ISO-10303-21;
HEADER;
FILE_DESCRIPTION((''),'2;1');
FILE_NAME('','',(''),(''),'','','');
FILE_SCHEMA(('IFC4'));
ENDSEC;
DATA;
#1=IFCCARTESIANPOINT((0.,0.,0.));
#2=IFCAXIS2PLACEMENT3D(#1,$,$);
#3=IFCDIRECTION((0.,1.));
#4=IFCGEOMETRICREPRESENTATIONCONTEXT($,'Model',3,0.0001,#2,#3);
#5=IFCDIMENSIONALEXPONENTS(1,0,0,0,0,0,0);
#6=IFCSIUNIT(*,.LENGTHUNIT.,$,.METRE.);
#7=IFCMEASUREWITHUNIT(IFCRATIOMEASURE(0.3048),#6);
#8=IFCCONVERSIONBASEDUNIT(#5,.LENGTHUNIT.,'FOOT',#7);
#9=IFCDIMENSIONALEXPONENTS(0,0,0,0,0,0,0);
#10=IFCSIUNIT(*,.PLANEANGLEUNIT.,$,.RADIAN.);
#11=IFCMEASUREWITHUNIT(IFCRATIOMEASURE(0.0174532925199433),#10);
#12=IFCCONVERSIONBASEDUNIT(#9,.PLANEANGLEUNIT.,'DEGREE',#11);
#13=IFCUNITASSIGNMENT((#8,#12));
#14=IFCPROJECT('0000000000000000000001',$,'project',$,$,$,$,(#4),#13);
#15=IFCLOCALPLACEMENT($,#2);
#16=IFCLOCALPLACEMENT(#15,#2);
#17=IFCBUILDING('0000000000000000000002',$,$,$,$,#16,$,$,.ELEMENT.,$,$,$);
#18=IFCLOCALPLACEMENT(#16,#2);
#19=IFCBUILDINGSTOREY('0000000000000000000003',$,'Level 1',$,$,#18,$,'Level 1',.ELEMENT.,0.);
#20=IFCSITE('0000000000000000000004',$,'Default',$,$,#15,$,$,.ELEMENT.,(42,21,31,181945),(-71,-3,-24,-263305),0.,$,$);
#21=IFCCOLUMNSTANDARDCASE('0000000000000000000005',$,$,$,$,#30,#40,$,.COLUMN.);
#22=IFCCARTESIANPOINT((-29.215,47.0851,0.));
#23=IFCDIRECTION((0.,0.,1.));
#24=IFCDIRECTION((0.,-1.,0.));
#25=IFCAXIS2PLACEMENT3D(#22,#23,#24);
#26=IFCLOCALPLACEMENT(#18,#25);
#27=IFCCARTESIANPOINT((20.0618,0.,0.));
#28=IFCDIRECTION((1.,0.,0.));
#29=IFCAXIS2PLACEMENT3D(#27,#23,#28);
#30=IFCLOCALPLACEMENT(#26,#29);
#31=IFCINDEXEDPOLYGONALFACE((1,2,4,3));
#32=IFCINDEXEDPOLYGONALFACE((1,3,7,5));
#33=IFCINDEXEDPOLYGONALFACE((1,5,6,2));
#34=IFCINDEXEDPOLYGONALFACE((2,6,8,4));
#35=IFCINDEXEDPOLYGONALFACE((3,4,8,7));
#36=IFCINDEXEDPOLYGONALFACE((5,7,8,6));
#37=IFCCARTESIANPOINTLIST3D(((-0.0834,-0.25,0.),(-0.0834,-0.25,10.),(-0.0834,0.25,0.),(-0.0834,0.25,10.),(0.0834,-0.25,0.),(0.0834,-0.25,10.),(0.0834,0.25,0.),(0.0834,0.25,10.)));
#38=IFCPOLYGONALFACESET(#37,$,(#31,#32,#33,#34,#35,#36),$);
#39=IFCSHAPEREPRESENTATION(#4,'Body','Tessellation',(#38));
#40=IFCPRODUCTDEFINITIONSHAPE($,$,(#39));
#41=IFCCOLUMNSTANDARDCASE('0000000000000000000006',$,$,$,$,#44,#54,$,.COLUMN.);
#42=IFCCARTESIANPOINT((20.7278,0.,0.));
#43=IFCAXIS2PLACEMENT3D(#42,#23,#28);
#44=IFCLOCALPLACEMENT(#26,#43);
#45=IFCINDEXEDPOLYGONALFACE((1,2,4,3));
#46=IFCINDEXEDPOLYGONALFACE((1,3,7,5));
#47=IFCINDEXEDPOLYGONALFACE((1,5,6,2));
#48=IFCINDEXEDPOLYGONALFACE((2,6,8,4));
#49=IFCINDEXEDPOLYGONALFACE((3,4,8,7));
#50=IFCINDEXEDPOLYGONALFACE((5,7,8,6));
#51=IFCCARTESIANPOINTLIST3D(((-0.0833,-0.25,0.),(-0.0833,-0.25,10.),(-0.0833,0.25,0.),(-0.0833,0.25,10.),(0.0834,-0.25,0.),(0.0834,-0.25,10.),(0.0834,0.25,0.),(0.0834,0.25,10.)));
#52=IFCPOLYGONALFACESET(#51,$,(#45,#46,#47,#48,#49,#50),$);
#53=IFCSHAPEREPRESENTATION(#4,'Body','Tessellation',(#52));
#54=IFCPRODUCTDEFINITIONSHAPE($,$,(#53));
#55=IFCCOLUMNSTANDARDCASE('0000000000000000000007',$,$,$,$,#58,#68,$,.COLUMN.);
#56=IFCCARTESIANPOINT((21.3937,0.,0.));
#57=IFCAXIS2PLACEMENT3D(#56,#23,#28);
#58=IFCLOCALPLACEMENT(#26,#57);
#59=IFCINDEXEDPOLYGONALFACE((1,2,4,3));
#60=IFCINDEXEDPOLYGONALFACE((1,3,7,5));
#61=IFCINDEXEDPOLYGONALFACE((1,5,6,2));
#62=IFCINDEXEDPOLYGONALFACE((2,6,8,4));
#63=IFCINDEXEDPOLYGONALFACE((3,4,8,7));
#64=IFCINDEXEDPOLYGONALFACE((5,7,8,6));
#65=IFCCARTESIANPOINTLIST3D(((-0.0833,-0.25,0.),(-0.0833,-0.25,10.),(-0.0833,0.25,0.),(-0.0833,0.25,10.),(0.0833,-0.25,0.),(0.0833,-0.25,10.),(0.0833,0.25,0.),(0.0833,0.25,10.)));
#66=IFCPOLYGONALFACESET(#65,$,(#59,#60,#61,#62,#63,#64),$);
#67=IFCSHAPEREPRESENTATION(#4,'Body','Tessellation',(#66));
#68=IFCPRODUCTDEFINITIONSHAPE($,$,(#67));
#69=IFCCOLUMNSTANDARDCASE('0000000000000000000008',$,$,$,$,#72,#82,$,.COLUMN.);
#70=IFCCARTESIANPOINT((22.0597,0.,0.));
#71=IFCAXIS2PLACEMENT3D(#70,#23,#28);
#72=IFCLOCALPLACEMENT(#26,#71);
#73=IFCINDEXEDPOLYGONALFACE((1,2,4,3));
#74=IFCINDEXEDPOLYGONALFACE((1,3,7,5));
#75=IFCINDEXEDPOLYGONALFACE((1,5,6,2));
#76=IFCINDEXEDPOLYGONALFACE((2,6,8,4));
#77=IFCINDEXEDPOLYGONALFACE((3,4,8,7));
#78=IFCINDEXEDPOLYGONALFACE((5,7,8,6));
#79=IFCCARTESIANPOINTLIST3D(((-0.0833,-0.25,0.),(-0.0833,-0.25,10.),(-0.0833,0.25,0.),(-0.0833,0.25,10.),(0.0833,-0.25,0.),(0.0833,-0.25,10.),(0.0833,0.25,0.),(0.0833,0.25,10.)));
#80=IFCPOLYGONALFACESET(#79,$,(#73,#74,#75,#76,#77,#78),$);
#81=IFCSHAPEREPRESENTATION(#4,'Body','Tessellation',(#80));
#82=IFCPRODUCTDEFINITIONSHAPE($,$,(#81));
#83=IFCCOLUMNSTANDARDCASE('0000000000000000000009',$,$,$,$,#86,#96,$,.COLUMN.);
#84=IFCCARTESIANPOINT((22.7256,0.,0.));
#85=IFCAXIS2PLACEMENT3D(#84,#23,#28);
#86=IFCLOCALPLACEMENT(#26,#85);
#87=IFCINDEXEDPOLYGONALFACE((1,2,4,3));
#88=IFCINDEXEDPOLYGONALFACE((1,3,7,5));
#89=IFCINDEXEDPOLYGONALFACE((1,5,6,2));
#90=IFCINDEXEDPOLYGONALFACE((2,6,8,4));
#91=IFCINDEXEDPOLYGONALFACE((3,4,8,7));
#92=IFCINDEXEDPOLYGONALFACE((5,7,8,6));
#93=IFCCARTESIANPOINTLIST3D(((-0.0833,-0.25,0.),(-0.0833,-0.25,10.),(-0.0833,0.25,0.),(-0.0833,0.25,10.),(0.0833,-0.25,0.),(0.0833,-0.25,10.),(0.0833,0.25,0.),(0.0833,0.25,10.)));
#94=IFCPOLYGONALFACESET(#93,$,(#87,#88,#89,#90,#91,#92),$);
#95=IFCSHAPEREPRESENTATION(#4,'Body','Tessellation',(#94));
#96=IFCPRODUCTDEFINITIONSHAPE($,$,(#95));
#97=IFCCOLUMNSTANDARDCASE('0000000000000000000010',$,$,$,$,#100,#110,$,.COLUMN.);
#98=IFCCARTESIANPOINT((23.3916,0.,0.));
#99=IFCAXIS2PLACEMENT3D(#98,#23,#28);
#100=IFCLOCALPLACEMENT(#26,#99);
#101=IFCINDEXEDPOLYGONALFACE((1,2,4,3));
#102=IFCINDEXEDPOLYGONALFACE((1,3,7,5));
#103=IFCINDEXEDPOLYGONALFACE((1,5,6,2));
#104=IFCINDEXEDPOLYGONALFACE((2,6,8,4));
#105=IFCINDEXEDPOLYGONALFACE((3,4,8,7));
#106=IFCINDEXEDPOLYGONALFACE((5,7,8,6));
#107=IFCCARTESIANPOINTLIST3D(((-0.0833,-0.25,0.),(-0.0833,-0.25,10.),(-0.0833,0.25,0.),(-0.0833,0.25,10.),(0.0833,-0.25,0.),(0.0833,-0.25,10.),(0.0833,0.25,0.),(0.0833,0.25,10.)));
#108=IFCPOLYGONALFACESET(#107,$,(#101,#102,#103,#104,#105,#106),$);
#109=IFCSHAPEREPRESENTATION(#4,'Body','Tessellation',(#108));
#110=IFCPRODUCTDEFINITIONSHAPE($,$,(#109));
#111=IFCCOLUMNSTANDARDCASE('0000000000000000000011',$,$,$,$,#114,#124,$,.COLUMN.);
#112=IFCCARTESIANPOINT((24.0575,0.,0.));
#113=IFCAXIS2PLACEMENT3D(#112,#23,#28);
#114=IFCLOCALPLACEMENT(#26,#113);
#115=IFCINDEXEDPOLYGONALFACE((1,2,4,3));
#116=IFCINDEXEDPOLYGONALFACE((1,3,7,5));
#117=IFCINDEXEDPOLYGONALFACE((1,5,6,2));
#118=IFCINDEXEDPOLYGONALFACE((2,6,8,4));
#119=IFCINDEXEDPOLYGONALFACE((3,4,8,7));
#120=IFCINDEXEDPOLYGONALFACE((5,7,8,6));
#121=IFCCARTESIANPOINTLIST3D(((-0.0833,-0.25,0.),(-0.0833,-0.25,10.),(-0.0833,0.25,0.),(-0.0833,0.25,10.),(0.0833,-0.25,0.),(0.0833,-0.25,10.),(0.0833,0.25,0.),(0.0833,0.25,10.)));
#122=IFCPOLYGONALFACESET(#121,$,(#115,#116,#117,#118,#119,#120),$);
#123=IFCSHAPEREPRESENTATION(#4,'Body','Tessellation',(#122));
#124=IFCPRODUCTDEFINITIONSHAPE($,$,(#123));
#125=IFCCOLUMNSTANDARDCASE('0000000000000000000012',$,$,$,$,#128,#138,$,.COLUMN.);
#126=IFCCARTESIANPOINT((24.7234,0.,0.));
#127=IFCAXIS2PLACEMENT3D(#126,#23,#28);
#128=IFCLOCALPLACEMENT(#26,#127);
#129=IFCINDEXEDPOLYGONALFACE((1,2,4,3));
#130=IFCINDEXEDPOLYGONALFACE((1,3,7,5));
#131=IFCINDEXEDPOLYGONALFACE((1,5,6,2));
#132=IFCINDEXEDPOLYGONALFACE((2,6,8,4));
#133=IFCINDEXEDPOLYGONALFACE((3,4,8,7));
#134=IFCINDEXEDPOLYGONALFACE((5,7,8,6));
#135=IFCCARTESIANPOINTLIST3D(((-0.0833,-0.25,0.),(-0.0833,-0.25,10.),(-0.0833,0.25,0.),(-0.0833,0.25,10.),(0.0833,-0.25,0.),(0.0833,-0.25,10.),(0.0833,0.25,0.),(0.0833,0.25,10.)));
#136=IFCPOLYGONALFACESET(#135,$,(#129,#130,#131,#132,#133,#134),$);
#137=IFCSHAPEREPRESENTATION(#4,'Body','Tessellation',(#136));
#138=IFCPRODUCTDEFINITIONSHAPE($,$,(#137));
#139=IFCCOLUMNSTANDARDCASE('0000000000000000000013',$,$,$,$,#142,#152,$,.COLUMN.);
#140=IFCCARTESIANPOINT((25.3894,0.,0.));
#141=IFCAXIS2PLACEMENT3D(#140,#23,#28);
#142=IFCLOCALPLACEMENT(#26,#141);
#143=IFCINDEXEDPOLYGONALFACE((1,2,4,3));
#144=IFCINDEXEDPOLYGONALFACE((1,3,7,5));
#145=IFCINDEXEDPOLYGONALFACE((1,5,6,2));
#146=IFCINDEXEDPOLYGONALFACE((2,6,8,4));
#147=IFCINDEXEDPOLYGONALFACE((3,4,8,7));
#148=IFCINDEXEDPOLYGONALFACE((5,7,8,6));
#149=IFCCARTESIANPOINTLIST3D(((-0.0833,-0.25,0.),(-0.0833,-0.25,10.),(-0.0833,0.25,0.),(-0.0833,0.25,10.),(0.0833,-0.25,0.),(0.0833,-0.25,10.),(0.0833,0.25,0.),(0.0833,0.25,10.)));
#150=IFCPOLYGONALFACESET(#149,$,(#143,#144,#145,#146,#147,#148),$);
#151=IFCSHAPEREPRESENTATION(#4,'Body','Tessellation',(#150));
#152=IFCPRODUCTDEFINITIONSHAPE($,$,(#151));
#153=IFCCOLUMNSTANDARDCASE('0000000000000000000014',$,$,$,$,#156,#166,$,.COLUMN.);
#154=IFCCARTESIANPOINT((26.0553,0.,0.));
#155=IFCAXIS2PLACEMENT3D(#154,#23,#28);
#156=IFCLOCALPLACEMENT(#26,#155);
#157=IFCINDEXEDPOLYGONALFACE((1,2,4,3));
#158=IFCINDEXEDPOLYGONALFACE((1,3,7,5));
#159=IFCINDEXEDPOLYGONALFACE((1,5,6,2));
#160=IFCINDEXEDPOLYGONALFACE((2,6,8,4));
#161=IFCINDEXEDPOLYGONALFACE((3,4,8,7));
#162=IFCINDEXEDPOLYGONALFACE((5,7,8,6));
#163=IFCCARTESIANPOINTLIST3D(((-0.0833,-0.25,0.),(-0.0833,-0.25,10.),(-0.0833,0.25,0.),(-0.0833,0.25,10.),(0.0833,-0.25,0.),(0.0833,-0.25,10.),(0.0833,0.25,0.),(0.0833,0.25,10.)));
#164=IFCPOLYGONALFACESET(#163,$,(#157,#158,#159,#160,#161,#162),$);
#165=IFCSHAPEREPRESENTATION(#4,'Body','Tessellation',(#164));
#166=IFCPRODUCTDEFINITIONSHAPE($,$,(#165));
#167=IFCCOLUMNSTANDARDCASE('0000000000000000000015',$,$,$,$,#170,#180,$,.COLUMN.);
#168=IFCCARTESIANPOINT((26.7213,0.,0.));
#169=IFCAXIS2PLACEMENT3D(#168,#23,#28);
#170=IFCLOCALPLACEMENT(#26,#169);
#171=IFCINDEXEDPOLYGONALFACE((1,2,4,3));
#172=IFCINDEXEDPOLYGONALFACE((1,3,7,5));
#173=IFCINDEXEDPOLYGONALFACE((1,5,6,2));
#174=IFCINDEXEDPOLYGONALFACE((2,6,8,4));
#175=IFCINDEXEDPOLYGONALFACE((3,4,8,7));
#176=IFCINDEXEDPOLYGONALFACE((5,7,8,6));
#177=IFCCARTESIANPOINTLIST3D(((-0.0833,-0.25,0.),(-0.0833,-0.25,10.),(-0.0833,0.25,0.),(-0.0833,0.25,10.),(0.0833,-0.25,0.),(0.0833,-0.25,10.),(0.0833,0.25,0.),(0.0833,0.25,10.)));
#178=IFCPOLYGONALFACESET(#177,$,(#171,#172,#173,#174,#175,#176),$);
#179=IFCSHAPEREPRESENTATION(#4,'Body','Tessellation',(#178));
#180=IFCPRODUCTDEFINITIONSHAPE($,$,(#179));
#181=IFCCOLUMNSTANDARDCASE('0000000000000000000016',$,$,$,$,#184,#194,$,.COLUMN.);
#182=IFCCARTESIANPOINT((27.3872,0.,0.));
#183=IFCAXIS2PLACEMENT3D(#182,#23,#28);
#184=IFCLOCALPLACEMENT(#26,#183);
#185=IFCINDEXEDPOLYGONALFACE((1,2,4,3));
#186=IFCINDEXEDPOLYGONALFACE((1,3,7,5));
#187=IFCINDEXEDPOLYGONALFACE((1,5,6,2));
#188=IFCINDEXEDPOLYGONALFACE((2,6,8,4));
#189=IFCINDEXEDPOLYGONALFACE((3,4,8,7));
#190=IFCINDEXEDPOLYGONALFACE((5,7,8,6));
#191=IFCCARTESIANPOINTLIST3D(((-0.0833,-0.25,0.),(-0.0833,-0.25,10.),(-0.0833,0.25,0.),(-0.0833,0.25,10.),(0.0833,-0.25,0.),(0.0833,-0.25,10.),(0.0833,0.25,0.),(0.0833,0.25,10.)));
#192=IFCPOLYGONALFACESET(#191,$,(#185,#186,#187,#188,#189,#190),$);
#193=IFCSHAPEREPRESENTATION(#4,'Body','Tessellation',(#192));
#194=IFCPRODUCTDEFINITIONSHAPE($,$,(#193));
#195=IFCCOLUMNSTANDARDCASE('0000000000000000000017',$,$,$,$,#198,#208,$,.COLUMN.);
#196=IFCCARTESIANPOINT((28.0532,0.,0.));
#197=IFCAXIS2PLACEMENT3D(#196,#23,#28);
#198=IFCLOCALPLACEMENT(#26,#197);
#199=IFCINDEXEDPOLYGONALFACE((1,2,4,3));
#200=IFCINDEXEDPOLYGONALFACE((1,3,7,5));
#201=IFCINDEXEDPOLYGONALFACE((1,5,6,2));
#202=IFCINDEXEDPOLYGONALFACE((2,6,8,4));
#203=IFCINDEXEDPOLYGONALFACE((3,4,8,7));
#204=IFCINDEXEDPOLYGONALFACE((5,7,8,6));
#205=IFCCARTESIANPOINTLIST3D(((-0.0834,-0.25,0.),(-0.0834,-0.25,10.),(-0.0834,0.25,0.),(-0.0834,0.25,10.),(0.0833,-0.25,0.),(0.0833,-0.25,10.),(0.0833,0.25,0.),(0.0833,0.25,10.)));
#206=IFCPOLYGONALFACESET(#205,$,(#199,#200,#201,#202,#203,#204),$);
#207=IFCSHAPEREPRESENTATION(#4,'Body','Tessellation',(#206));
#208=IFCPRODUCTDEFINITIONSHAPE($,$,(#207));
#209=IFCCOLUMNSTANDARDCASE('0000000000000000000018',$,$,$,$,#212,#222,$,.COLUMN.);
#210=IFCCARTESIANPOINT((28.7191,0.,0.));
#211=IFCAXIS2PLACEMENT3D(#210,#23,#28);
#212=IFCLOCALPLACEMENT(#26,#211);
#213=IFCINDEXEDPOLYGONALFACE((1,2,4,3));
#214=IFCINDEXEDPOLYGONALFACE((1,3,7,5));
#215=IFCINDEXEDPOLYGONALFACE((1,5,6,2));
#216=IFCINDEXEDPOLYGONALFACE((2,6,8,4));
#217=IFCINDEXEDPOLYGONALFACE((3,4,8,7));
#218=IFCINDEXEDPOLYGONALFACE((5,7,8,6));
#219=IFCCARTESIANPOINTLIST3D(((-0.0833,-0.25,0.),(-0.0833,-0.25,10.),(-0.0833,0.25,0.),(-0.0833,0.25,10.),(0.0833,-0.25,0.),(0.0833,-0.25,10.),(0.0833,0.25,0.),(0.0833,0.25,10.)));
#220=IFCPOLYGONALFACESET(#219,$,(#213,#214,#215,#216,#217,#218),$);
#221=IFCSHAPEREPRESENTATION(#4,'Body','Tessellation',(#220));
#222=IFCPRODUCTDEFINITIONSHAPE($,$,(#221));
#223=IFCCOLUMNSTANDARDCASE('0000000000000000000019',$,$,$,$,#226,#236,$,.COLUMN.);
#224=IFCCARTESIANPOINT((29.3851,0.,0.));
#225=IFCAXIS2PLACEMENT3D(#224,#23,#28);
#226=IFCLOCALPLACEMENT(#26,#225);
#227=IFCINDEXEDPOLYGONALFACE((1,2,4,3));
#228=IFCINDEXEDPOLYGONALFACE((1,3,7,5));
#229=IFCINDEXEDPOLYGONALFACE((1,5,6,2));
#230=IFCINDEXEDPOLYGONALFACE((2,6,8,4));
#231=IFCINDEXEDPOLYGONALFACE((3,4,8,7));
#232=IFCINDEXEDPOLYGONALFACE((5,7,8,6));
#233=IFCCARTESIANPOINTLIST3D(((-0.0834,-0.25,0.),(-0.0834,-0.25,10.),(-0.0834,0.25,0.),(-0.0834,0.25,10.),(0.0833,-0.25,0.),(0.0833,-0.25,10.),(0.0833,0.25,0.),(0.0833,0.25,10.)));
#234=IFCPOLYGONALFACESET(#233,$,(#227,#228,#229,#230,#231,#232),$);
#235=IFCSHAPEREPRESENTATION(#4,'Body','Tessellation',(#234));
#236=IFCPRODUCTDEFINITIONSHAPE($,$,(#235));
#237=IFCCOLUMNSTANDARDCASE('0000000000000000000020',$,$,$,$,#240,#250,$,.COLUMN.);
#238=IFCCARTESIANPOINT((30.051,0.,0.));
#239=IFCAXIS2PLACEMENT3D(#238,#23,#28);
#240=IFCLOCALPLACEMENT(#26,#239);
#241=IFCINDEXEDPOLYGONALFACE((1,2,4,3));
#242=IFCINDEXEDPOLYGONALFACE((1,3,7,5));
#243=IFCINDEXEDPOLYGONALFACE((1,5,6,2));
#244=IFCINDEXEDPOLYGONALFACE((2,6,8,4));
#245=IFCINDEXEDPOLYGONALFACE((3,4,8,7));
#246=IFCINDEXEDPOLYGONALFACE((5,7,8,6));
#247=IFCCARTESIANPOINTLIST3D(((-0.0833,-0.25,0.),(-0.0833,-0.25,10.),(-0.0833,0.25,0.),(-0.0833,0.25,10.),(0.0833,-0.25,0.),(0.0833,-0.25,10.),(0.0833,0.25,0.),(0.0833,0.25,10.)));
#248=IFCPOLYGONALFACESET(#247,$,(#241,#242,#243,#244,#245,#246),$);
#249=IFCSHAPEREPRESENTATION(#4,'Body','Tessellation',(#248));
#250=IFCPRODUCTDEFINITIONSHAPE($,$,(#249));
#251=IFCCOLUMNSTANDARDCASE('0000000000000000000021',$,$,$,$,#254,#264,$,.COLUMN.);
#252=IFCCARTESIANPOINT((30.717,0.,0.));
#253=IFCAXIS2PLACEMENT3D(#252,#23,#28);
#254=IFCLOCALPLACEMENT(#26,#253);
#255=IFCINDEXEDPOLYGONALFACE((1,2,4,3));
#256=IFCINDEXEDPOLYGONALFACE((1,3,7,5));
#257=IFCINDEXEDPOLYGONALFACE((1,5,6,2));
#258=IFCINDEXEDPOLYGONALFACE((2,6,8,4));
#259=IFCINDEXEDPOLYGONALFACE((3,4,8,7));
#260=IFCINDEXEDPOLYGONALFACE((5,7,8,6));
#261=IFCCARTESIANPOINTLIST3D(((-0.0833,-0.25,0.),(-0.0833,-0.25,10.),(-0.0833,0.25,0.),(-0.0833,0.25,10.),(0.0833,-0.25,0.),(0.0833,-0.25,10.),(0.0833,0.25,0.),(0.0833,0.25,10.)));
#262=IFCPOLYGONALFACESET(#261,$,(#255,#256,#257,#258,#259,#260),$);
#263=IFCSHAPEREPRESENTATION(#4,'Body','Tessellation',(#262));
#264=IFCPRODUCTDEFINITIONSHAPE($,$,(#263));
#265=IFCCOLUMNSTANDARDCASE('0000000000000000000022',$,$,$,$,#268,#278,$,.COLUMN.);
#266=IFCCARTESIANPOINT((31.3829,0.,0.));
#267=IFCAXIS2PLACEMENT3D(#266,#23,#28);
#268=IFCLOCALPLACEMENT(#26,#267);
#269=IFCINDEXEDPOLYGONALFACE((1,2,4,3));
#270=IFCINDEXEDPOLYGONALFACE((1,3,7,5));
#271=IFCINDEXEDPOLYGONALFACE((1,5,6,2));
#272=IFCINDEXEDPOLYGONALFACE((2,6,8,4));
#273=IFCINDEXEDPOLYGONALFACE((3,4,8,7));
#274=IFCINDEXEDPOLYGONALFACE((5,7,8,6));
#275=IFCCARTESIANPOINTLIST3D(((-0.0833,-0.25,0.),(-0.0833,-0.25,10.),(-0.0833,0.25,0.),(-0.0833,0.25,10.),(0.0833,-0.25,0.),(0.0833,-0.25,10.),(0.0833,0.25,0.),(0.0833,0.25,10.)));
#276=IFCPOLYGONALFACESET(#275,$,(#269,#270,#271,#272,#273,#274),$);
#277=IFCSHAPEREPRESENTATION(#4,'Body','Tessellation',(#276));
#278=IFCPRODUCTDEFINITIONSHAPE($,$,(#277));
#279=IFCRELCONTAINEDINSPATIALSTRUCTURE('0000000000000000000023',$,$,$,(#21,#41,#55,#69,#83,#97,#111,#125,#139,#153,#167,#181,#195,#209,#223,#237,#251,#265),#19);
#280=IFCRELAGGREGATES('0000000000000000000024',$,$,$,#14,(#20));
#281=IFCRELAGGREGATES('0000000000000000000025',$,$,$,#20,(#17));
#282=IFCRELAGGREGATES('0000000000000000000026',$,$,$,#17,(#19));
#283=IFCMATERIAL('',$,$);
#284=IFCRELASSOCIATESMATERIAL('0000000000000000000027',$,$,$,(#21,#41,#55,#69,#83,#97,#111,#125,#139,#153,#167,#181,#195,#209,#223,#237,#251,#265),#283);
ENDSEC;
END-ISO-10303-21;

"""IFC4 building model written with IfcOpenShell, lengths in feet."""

from ifc_helpers import new_model, entity, si_unit, converted_unit, direction, frame, origin, place, context, project, spatial, rectangle, extrude, material, element, save


model = new_model("IFC4")

# Units and contexts
model_context = context("Model", 3, precision=0.0001, world=origin(), true_north=direction((0.0, 1.0)))
ifc_project = project(units=[converted_unit("LENGTHUNIT", "FOOT", entity("IfcRatioMeasure", 0.3048), si_unit("LENGTHUNIT", "METRE"), dimensions=[1, 0, 0, 0, 0, 0, 0]), converted_unit("PLANEANGLEUNIT", "DEGREE", entity("IfcRatioMeasure", 0.0174532925199433), si_unit("PLANEANGLEUNIT", "RADIAN"), dimensions=[0, 0, 0, 0, 0, 0, 0])], contexts=[model_context])

# Site, building, storey
site_placement = place(None, origin())
site = spatial("IfcSite", under=ifc_project, at=site_placement, Name="Default", CompositionType="ELEMENT", RefLatitude=(42, 21, 31, 181945), RefLongitude=(-71, -3, -24, -263305), RefElevation=0.0)
building_placement = place(site_placement, origin())
building = spatial("IfcBuilding", under=site, at=building_placement, CompositionType="ELEMENT")
storey_placement = place(building_placement, origin())
storey = spatial("IfcBuildingStorey", under=building, at=storey_placement, Name="Level 1", LongName="Level 1", CompositionType="ELEMENT", Elevation=0.0)

# Columns
ifc_material_1 = material(Name="")
placement_1 = place(storey_placement, frame((-29.215, 47.0851, 0.0), z_axis=(0.0, 0.0, 1.0), x_axis=(0.0, -1.0, 0.0)))
for number, where, z_axis, x_axis in (
    (1, (20.0618, 0.0, 0.0), (0.0, 0.0, 1.0), (1.0, 0.0, 0.0)),
    (2, (20.7278, 0.0, 0.0), (0.0, 0.0, 1.0), (1.0, 0.0, 0.0)),
    (3, (21.3937, 0.0, 0.0), (0.0, 0.0, 1.0), (1.0, 0.0, 0.0)),
    (4, (22.0597, 0.0, 0.0), (0.0, 0.0, 1.0), (1.0, 0.0, 0.0)),
    (5, (22.7256, 0.0, 0.0), (0.0, 0.0, 1.0), (1.0, 0.0, 0.0)),
    (6, (23.3916, 0.0, 0.0), (0.0, 0.0, 1.0), (1.0, 0.0, 0.0)),
    (7, (24.0575, 0.0, 0.0), (0.0, 0.0, 1.0), (1.0, 0.0, 0.0)),
    (8, (24.7234, 0.0, 0.0), (0.0, 0.0, 1.0), (1.0, 0.0, 0.0)),
    (9, (25.3894, 0.0, 0.0), (0.0, 0.0, 1.0), (1.0, 0.0, 0.0)),
    (10, (26.0553, 0.0, 0.0), (0.0, 0.0, 1.0), (1.0, 0.0, 0.0)),
    (11, (26.7213, 0.0, 0.0), (0.0, 0.0, 1.0), (1.0, 0.0, 0.0)),
    (12, (27.3872, 0.0, 0.0), (0.0, 0.0, 1.0), (1.0, 0.0, 0.0)),
    (13, (28.0532, 0.0, 0.0), (0.0, 0.0, 1.0), (1.0, 0.0, 0.0)),
    (14, (28.7191, 0.0, 0.0), (0.0, 0.0, 1.0), (1.0, 0.0, 0.0)),
    (15, (29.3851, 0.0, 0.0), (0.0, 0.0, 1.0), (1.0, 0.0, 0.0)),
    (16, (30.051, 0.0, 0.0), (0.0, 0.0, 1.0), (1.0, 0.0, 0.0)),
    (17, (30.717, 0.0, 0.0), (0.0, 0.0, 1.0), (1.0, 0.0, 0.0)),
    (18, (31.3829, 0.0, 0.0), (0.0, 0.0, 1.0), (1.0, 0.0, 0.0)),
):
    element("IfcColumnStandardCase", number, at=place(placement_1, frame(where, z_axis=z_axis, x_axis=x_axis)), inside=storey, material=ifc_material_1, PredefinedType="COLUMN", context=model_context, shape_type="SweptSolid", body=[
        extrude(rectangle(XDim=0.1667, YDim=0.5), origin(), (0.0, 0.0, 1.0), 10.0),
    ])

save(model, "model.ifc")
